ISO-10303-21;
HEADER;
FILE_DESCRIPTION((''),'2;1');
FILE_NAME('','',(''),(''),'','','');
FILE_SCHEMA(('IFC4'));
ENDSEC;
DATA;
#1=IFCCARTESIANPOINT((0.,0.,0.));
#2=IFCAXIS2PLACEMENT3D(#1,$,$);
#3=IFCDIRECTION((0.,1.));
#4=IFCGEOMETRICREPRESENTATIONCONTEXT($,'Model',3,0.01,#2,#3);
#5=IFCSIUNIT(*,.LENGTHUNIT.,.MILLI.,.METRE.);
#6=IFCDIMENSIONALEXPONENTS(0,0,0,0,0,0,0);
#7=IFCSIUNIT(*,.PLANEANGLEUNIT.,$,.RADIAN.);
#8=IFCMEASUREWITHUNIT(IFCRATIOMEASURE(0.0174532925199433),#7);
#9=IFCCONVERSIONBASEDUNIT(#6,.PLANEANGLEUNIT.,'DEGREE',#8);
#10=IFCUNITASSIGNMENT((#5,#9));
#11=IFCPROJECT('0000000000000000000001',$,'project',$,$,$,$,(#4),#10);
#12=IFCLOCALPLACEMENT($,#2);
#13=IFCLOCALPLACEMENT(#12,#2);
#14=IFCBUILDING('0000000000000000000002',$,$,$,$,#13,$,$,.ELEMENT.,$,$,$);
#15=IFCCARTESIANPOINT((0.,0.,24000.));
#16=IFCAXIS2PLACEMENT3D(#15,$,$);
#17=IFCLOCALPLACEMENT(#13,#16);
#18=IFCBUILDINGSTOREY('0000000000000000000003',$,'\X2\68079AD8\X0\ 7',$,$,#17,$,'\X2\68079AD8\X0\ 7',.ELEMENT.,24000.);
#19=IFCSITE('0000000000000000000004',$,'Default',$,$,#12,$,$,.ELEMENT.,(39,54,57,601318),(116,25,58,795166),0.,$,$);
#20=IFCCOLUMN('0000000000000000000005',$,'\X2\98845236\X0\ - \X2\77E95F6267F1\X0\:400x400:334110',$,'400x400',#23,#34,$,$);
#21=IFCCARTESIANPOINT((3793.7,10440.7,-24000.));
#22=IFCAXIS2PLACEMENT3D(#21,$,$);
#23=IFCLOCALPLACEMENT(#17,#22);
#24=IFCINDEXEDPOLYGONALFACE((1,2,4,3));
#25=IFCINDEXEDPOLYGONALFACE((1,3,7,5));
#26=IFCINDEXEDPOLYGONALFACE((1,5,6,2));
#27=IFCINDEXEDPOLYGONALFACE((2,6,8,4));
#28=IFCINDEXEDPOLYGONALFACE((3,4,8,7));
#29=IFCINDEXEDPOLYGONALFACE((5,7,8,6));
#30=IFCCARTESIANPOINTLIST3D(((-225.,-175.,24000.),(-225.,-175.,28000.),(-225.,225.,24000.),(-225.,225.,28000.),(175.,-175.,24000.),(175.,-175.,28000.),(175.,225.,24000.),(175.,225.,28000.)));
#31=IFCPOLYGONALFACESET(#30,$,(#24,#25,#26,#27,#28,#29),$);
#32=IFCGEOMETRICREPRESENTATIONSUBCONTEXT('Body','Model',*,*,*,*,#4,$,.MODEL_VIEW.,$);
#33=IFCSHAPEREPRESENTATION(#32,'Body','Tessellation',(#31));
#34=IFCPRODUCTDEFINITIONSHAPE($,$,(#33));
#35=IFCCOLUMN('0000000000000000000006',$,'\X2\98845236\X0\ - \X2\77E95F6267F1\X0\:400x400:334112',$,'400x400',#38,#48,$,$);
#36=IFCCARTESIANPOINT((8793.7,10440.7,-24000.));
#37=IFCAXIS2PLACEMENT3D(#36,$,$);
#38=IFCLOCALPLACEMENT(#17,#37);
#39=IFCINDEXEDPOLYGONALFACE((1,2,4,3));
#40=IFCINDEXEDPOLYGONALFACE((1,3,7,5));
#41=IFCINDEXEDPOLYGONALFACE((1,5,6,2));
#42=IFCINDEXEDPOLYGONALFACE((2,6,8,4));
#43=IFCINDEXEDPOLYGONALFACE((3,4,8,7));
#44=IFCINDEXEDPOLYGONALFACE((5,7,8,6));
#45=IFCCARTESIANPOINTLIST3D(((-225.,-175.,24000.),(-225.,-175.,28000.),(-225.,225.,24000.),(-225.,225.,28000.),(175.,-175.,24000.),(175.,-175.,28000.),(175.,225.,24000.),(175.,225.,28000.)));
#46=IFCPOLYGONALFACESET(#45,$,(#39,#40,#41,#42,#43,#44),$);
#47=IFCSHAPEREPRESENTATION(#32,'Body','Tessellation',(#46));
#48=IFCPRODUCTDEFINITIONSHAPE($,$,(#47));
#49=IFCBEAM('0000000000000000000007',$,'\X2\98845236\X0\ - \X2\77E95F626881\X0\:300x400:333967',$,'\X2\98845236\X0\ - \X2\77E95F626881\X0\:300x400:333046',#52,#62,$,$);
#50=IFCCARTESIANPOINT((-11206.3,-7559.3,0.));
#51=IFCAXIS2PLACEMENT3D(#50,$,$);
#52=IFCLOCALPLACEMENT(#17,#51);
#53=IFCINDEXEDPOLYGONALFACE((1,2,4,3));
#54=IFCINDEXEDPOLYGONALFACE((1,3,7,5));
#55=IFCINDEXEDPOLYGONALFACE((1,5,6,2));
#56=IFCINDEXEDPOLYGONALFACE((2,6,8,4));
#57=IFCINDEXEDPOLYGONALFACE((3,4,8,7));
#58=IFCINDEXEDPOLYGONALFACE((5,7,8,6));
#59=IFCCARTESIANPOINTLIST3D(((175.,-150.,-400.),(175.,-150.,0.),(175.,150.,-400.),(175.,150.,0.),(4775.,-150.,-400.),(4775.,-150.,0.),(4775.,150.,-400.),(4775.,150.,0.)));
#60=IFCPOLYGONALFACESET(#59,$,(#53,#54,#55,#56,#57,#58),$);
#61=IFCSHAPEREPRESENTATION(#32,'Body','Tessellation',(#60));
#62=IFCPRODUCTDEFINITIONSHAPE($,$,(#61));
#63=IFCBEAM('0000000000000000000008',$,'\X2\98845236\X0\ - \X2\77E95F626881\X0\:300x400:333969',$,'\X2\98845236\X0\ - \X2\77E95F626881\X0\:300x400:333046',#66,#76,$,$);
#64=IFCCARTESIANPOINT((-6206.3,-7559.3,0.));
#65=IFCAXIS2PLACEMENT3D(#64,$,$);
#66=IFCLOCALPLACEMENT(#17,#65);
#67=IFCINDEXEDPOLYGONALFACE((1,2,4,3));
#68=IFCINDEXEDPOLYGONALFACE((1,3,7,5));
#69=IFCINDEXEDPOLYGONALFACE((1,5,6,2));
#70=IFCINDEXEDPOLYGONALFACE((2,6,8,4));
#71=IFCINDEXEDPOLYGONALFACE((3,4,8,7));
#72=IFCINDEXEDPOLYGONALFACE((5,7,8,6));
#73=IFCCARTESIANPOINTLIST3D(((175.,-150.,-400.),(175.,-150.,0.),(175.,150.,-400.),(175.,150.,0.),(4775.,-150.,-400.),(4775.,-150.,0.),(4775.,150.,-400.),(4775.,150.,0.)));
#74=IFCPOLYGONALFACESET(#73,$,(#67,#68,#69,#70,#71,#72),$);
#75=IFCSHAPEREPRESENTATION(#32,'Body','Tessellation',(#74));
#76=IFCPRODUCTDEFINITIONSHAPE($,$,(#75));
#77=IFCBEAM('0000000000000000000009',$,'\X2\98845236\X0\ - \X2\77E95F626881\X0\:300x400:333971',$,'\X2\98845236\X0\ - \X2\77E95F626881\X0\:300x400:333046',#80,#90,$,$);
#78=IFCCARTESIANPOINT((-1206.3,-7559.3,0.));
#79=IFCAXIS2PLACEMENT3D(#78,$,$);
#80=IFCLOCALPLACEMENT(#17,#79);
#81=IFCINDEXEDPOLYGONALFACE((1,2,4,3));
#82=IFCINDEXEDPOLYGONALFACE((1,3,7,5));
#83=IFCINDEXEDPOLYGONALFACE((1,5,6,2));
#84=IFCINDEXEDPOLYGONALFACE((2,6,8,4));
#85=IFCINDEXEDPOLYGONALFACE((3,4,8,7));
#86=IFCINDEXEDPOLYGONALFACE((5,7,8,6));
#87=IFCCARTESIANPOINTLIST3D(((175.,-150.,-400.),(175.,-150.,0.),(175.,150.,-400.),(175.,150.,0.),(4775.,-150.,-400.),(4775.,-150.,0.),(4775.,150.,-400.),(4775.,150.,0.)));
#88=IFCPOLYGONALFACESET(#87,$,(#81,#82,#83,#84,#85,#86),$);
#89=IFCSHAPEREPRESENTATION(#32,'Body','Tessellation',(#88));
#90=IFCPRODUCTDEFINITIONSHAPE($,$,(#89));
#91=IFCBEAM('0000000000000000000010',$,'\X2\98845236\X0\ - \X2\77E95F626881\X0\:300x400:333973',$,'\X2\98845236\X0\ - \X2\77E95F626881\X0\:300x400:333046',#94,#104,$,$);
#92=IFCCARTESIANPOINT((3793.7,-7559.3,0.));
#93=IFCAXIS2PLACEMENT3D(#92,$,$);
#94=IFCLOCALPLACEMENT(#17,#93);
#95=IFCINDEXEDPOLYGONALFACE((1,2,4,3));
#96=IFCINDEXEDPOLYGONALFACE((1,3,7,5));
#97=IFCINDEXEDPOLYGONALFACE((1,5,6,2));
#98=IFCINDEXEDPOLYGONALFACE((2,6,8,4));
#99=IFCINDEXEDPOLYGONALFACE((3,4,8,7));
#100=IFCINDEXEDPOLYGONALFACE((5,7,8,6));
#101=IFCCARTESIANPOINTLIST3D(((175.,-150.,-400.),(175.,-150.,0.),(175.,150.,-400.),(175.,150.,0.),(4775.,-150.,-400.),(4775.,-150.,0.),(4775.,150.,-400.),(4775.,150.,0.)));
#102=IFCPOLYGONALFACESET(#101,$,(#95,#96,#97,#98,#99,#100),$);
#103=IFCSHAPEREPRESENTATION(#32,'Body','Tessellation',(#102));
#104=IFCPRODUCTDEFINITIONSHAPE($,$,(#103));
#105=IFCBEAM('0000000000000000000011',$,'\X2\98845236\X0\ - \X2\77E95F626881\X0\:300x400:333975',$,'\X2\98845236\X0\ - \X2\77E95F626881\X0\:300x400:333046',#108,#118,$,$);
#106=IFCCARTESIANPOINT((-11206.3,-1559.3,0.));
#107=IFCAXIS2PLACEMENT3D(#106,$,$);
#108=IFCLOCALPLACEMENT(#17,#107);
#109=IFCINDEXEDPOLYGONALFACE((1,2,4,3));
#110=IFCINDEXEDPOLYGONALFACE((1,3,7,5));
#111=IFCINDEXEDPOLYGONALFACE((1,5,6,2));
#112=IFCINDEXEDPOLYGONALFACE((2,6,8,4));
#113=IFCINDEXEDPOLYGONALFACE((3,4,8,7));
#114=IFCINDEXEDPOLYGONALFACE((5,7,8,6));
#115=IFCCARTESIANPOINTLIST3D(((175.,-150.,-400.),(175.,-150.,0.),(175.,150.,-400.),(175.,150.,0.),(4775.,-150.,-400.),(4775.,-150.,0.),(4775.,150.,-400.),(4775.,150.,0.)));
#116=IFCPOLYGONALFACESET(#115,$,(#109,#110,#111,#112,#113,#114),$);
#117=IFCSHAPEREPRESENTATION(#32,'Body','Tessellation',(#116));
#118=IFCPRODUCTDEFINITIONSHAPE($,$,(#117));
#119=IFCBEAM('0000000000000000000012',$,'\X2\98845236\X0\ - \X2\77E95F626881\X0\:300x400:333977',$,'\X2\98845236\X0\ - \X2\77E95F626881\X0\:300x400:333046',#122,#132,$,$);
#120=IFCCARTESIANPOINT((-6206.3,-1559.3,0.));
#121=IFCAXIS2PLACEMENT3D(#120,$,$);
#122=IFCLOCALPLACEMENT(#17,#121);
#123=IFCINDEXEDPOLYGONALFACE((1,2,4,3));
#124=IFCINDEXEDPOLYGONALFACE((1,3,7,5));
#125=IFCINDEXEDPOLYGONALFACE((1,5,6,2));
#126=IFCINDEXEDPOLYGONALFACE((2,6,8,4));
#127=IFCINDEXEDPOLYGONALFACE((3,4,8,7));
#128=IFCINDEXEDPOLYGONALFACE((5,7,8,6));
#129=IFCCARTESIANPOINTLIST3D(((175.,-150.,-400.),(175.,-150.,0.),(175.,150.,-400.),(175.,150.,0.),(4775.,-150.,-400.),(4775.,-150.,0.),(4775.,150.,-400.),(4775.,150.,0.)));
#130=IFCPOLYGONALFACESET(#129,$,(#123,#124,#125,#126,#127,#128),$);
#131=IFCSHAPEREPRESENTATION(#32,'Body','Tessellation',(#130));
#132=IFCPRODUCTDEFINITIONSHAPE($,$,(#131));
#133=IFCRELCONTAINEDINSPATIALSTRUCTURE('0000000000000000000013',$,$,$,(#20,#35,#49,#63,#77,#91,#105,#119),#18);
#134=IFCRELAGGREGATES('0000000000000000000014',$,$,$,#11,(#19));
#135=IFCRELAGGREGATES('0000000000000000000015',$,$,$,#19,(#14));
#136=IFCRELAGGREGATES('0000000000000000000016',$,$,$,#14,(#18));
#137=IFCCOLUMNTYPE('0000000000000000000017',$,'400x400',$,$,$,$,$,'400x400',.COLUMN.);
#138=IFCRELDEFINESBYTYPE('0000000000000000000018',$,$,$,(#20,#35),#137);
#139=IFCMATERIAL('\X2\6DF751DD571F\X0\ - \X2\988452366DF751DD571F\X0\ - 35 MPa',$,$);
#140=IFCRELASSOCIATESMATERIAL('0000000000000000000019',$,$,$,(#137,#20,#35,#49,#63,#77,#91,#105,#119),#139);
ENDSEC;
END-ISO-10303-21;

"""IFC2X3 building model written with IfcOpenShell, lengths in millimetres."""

from ifc_helpers import new_model, entity, si_unit, converted_unit, direction, frame, frame_2d, origin, place, context, subcontext, project, spatial, rectangle, extrude, source, transform, mapped, material, type_object, type_shapes, element, save


model = new_model("IFC2X3")

# Units and contexts
model_context = context("Model", 3, precision=0.01, world=origin(), true_north=direction((0.0, 1.0)))
body_context = subcontext(model_context, "Body", "Model", "MODEL_VIEW")
ifc_project = project(units=[si_unit("LENGTHUNIT", "METRE", prefix="MILLI"), converted_unit("PLANEANGLEUNIT", "DEGREE", entity("IfcRatioMeasure", 0.0174532925199433), si_unit("PLANEANGLEUNIT", "RADIAN"), dimensions=[0, 0, 0, 0, 0, 0, 0])], contexts=[model_context])

# Site, building, storey
site_placement = place(None, origin())
site = spatial("IfcSite", under=ifc_project, at=site_placement, Name="Default", CompositionType="ELEMENT", RefLatitude=(39, 54, 57, 601318), RefLongitude=(116, 25, 58, 795166), RefElevation=0.0)
building_placement = place(site_placement, origin())
building = spatial("IfcBuilding", under=site, at=building_placement, CompositionType="ELEMENT")
storey_placement = place(building_placement, frame((0.0, 0.0, 24000.0)))
storey = spatial("IfcBuildingStorey", under=building, at=storey_placement, Name="标高 7", LongName="标高 7", CompositionType="ELEMENT", Elevation=24000.0)

# Columns
ifc_material = material(Name="混凝土 - 预制混凝土 - 35 MPa")
column_type = type_object("IfcColumnType", Name="400x400", ElementType="400x400", PredefinedType="COLUMN", material=ifc_material)
shared_shape = source(origin(), body_context, "Body", "SweptSolid", [
    extrude(rectangle(XDim=400.0, YDim=400.0, at=frame_2d((0.0, 0.0), x_axis=(1.0, 0.0))), frame((-25.0, 25.0, 24000.0)), (0.0, 0.0, 1.0), 4000.0),
])
type_shapes(column_type, [shared_shape])
for number, where, name in (
    (1, (3793.7, 10440.7, -24000.0), "预制 - 矩形柱:400x400:334110"),
    (2, (8793.7, 10440.7, -24000.0), "预制 - 矩形柱:400x400:334112"),
):
    element("IfcColumn", number, at=place(storey_placement, frame(where)), inside=storey, type_object=column_type, material=ifc_material, Name=name, ObjectType="400x400", context=body_context, shape_type="MappedRepresentation", body=[
        mapped(shared_shape, transform((0.0, 0.0, 0.0), scale=1.0)),
    ])

# Beams
for number, where, name in (
    (3, (-11206.3, -7559.3, 0.0), "预制 - 矩形梁:300x400:333967"),
    (4, (-6206.3, -7559.3, 0.0), "预制 - 矩形梁:300x400:333969"),
):
    element("IfcBeam", number, at=place(storey_placement, frame(where)), inside=storey, material=ifc_material, Name=name, ObjectType="预制 - 矩形梁:300x400:333046", context=body_context, shape_type="SweptSolid", body=[
        extrude(rectangle(XDim=400.0, YDim=300.0, at=frame_2d((0.0, 0.0), x_axis=(1.0, 0.0))), frame((175.0, 0.0, -200.0), z_axis=(1.0, 0.0, 0.0), x_axis=(0.0, 0.0, -1.0)), (0.0, 0.0, 1.0), 4600.0),
    ])
for number, where, name in (
    (5, (-1206.3, -7559.3, 0.0), "预制 - 矩形梁:300x400:333971"),
    (6, (3793.7, -7559.3, 0.0), "预制 - 矩形梁:300x400:333973"),
):
    element("IfcBeam", number, at=place(storey_placement, frame(where)), inside=storey, material=ifc_material, Name=name, ObjectType="预制 - 矩形梁:300x400:333046", context=body_context, shape_type="SweptSolid", body=[
        extrude(rectangle(XDim=400.0, YDim=300.0, at=frame_2d((0.0, 0.0), x_axis=(1.0, 0.0))), frame((175.0, 0.0, -200.0), z_axis=(1.0, 0.0, 0.0), x_axis=(0.0, 0.0, -1.0)), (0.0, 0.0, 1.0), 4600.0),
    ])
for number, where, name in (
    (7, (-11206.3, -1559.3, 0.0), "预制 - 矩形梁:300x400:333975"),
    (8, (-6206.3, -1559.3, 0.0), "预制 - 矩形梁:300x400:333977"),
):
    element("IfcBeam", number, at=place(storey_placement, frame(where)), inside=storey, material=ifc_material, Name=name, ObjectType="预制 - 矩形梁:300x400:333046", context=body_context, shape_type="SweptSolid", body=[
        extrude(rectangle(XDim=400.0, YDim=300.0, at=frame_2d((0.0, 0.0), x_axis=(1.0, 0.0))), frame((175.0, 0.0, -200.0), z_axis=(1.0, 0.0, 0.0), x_axis=(0.0, 0.0, -1.0)), (0.0, 0.0, 1.0), 4600.0),
    ])

save(model, "model.ifc")
